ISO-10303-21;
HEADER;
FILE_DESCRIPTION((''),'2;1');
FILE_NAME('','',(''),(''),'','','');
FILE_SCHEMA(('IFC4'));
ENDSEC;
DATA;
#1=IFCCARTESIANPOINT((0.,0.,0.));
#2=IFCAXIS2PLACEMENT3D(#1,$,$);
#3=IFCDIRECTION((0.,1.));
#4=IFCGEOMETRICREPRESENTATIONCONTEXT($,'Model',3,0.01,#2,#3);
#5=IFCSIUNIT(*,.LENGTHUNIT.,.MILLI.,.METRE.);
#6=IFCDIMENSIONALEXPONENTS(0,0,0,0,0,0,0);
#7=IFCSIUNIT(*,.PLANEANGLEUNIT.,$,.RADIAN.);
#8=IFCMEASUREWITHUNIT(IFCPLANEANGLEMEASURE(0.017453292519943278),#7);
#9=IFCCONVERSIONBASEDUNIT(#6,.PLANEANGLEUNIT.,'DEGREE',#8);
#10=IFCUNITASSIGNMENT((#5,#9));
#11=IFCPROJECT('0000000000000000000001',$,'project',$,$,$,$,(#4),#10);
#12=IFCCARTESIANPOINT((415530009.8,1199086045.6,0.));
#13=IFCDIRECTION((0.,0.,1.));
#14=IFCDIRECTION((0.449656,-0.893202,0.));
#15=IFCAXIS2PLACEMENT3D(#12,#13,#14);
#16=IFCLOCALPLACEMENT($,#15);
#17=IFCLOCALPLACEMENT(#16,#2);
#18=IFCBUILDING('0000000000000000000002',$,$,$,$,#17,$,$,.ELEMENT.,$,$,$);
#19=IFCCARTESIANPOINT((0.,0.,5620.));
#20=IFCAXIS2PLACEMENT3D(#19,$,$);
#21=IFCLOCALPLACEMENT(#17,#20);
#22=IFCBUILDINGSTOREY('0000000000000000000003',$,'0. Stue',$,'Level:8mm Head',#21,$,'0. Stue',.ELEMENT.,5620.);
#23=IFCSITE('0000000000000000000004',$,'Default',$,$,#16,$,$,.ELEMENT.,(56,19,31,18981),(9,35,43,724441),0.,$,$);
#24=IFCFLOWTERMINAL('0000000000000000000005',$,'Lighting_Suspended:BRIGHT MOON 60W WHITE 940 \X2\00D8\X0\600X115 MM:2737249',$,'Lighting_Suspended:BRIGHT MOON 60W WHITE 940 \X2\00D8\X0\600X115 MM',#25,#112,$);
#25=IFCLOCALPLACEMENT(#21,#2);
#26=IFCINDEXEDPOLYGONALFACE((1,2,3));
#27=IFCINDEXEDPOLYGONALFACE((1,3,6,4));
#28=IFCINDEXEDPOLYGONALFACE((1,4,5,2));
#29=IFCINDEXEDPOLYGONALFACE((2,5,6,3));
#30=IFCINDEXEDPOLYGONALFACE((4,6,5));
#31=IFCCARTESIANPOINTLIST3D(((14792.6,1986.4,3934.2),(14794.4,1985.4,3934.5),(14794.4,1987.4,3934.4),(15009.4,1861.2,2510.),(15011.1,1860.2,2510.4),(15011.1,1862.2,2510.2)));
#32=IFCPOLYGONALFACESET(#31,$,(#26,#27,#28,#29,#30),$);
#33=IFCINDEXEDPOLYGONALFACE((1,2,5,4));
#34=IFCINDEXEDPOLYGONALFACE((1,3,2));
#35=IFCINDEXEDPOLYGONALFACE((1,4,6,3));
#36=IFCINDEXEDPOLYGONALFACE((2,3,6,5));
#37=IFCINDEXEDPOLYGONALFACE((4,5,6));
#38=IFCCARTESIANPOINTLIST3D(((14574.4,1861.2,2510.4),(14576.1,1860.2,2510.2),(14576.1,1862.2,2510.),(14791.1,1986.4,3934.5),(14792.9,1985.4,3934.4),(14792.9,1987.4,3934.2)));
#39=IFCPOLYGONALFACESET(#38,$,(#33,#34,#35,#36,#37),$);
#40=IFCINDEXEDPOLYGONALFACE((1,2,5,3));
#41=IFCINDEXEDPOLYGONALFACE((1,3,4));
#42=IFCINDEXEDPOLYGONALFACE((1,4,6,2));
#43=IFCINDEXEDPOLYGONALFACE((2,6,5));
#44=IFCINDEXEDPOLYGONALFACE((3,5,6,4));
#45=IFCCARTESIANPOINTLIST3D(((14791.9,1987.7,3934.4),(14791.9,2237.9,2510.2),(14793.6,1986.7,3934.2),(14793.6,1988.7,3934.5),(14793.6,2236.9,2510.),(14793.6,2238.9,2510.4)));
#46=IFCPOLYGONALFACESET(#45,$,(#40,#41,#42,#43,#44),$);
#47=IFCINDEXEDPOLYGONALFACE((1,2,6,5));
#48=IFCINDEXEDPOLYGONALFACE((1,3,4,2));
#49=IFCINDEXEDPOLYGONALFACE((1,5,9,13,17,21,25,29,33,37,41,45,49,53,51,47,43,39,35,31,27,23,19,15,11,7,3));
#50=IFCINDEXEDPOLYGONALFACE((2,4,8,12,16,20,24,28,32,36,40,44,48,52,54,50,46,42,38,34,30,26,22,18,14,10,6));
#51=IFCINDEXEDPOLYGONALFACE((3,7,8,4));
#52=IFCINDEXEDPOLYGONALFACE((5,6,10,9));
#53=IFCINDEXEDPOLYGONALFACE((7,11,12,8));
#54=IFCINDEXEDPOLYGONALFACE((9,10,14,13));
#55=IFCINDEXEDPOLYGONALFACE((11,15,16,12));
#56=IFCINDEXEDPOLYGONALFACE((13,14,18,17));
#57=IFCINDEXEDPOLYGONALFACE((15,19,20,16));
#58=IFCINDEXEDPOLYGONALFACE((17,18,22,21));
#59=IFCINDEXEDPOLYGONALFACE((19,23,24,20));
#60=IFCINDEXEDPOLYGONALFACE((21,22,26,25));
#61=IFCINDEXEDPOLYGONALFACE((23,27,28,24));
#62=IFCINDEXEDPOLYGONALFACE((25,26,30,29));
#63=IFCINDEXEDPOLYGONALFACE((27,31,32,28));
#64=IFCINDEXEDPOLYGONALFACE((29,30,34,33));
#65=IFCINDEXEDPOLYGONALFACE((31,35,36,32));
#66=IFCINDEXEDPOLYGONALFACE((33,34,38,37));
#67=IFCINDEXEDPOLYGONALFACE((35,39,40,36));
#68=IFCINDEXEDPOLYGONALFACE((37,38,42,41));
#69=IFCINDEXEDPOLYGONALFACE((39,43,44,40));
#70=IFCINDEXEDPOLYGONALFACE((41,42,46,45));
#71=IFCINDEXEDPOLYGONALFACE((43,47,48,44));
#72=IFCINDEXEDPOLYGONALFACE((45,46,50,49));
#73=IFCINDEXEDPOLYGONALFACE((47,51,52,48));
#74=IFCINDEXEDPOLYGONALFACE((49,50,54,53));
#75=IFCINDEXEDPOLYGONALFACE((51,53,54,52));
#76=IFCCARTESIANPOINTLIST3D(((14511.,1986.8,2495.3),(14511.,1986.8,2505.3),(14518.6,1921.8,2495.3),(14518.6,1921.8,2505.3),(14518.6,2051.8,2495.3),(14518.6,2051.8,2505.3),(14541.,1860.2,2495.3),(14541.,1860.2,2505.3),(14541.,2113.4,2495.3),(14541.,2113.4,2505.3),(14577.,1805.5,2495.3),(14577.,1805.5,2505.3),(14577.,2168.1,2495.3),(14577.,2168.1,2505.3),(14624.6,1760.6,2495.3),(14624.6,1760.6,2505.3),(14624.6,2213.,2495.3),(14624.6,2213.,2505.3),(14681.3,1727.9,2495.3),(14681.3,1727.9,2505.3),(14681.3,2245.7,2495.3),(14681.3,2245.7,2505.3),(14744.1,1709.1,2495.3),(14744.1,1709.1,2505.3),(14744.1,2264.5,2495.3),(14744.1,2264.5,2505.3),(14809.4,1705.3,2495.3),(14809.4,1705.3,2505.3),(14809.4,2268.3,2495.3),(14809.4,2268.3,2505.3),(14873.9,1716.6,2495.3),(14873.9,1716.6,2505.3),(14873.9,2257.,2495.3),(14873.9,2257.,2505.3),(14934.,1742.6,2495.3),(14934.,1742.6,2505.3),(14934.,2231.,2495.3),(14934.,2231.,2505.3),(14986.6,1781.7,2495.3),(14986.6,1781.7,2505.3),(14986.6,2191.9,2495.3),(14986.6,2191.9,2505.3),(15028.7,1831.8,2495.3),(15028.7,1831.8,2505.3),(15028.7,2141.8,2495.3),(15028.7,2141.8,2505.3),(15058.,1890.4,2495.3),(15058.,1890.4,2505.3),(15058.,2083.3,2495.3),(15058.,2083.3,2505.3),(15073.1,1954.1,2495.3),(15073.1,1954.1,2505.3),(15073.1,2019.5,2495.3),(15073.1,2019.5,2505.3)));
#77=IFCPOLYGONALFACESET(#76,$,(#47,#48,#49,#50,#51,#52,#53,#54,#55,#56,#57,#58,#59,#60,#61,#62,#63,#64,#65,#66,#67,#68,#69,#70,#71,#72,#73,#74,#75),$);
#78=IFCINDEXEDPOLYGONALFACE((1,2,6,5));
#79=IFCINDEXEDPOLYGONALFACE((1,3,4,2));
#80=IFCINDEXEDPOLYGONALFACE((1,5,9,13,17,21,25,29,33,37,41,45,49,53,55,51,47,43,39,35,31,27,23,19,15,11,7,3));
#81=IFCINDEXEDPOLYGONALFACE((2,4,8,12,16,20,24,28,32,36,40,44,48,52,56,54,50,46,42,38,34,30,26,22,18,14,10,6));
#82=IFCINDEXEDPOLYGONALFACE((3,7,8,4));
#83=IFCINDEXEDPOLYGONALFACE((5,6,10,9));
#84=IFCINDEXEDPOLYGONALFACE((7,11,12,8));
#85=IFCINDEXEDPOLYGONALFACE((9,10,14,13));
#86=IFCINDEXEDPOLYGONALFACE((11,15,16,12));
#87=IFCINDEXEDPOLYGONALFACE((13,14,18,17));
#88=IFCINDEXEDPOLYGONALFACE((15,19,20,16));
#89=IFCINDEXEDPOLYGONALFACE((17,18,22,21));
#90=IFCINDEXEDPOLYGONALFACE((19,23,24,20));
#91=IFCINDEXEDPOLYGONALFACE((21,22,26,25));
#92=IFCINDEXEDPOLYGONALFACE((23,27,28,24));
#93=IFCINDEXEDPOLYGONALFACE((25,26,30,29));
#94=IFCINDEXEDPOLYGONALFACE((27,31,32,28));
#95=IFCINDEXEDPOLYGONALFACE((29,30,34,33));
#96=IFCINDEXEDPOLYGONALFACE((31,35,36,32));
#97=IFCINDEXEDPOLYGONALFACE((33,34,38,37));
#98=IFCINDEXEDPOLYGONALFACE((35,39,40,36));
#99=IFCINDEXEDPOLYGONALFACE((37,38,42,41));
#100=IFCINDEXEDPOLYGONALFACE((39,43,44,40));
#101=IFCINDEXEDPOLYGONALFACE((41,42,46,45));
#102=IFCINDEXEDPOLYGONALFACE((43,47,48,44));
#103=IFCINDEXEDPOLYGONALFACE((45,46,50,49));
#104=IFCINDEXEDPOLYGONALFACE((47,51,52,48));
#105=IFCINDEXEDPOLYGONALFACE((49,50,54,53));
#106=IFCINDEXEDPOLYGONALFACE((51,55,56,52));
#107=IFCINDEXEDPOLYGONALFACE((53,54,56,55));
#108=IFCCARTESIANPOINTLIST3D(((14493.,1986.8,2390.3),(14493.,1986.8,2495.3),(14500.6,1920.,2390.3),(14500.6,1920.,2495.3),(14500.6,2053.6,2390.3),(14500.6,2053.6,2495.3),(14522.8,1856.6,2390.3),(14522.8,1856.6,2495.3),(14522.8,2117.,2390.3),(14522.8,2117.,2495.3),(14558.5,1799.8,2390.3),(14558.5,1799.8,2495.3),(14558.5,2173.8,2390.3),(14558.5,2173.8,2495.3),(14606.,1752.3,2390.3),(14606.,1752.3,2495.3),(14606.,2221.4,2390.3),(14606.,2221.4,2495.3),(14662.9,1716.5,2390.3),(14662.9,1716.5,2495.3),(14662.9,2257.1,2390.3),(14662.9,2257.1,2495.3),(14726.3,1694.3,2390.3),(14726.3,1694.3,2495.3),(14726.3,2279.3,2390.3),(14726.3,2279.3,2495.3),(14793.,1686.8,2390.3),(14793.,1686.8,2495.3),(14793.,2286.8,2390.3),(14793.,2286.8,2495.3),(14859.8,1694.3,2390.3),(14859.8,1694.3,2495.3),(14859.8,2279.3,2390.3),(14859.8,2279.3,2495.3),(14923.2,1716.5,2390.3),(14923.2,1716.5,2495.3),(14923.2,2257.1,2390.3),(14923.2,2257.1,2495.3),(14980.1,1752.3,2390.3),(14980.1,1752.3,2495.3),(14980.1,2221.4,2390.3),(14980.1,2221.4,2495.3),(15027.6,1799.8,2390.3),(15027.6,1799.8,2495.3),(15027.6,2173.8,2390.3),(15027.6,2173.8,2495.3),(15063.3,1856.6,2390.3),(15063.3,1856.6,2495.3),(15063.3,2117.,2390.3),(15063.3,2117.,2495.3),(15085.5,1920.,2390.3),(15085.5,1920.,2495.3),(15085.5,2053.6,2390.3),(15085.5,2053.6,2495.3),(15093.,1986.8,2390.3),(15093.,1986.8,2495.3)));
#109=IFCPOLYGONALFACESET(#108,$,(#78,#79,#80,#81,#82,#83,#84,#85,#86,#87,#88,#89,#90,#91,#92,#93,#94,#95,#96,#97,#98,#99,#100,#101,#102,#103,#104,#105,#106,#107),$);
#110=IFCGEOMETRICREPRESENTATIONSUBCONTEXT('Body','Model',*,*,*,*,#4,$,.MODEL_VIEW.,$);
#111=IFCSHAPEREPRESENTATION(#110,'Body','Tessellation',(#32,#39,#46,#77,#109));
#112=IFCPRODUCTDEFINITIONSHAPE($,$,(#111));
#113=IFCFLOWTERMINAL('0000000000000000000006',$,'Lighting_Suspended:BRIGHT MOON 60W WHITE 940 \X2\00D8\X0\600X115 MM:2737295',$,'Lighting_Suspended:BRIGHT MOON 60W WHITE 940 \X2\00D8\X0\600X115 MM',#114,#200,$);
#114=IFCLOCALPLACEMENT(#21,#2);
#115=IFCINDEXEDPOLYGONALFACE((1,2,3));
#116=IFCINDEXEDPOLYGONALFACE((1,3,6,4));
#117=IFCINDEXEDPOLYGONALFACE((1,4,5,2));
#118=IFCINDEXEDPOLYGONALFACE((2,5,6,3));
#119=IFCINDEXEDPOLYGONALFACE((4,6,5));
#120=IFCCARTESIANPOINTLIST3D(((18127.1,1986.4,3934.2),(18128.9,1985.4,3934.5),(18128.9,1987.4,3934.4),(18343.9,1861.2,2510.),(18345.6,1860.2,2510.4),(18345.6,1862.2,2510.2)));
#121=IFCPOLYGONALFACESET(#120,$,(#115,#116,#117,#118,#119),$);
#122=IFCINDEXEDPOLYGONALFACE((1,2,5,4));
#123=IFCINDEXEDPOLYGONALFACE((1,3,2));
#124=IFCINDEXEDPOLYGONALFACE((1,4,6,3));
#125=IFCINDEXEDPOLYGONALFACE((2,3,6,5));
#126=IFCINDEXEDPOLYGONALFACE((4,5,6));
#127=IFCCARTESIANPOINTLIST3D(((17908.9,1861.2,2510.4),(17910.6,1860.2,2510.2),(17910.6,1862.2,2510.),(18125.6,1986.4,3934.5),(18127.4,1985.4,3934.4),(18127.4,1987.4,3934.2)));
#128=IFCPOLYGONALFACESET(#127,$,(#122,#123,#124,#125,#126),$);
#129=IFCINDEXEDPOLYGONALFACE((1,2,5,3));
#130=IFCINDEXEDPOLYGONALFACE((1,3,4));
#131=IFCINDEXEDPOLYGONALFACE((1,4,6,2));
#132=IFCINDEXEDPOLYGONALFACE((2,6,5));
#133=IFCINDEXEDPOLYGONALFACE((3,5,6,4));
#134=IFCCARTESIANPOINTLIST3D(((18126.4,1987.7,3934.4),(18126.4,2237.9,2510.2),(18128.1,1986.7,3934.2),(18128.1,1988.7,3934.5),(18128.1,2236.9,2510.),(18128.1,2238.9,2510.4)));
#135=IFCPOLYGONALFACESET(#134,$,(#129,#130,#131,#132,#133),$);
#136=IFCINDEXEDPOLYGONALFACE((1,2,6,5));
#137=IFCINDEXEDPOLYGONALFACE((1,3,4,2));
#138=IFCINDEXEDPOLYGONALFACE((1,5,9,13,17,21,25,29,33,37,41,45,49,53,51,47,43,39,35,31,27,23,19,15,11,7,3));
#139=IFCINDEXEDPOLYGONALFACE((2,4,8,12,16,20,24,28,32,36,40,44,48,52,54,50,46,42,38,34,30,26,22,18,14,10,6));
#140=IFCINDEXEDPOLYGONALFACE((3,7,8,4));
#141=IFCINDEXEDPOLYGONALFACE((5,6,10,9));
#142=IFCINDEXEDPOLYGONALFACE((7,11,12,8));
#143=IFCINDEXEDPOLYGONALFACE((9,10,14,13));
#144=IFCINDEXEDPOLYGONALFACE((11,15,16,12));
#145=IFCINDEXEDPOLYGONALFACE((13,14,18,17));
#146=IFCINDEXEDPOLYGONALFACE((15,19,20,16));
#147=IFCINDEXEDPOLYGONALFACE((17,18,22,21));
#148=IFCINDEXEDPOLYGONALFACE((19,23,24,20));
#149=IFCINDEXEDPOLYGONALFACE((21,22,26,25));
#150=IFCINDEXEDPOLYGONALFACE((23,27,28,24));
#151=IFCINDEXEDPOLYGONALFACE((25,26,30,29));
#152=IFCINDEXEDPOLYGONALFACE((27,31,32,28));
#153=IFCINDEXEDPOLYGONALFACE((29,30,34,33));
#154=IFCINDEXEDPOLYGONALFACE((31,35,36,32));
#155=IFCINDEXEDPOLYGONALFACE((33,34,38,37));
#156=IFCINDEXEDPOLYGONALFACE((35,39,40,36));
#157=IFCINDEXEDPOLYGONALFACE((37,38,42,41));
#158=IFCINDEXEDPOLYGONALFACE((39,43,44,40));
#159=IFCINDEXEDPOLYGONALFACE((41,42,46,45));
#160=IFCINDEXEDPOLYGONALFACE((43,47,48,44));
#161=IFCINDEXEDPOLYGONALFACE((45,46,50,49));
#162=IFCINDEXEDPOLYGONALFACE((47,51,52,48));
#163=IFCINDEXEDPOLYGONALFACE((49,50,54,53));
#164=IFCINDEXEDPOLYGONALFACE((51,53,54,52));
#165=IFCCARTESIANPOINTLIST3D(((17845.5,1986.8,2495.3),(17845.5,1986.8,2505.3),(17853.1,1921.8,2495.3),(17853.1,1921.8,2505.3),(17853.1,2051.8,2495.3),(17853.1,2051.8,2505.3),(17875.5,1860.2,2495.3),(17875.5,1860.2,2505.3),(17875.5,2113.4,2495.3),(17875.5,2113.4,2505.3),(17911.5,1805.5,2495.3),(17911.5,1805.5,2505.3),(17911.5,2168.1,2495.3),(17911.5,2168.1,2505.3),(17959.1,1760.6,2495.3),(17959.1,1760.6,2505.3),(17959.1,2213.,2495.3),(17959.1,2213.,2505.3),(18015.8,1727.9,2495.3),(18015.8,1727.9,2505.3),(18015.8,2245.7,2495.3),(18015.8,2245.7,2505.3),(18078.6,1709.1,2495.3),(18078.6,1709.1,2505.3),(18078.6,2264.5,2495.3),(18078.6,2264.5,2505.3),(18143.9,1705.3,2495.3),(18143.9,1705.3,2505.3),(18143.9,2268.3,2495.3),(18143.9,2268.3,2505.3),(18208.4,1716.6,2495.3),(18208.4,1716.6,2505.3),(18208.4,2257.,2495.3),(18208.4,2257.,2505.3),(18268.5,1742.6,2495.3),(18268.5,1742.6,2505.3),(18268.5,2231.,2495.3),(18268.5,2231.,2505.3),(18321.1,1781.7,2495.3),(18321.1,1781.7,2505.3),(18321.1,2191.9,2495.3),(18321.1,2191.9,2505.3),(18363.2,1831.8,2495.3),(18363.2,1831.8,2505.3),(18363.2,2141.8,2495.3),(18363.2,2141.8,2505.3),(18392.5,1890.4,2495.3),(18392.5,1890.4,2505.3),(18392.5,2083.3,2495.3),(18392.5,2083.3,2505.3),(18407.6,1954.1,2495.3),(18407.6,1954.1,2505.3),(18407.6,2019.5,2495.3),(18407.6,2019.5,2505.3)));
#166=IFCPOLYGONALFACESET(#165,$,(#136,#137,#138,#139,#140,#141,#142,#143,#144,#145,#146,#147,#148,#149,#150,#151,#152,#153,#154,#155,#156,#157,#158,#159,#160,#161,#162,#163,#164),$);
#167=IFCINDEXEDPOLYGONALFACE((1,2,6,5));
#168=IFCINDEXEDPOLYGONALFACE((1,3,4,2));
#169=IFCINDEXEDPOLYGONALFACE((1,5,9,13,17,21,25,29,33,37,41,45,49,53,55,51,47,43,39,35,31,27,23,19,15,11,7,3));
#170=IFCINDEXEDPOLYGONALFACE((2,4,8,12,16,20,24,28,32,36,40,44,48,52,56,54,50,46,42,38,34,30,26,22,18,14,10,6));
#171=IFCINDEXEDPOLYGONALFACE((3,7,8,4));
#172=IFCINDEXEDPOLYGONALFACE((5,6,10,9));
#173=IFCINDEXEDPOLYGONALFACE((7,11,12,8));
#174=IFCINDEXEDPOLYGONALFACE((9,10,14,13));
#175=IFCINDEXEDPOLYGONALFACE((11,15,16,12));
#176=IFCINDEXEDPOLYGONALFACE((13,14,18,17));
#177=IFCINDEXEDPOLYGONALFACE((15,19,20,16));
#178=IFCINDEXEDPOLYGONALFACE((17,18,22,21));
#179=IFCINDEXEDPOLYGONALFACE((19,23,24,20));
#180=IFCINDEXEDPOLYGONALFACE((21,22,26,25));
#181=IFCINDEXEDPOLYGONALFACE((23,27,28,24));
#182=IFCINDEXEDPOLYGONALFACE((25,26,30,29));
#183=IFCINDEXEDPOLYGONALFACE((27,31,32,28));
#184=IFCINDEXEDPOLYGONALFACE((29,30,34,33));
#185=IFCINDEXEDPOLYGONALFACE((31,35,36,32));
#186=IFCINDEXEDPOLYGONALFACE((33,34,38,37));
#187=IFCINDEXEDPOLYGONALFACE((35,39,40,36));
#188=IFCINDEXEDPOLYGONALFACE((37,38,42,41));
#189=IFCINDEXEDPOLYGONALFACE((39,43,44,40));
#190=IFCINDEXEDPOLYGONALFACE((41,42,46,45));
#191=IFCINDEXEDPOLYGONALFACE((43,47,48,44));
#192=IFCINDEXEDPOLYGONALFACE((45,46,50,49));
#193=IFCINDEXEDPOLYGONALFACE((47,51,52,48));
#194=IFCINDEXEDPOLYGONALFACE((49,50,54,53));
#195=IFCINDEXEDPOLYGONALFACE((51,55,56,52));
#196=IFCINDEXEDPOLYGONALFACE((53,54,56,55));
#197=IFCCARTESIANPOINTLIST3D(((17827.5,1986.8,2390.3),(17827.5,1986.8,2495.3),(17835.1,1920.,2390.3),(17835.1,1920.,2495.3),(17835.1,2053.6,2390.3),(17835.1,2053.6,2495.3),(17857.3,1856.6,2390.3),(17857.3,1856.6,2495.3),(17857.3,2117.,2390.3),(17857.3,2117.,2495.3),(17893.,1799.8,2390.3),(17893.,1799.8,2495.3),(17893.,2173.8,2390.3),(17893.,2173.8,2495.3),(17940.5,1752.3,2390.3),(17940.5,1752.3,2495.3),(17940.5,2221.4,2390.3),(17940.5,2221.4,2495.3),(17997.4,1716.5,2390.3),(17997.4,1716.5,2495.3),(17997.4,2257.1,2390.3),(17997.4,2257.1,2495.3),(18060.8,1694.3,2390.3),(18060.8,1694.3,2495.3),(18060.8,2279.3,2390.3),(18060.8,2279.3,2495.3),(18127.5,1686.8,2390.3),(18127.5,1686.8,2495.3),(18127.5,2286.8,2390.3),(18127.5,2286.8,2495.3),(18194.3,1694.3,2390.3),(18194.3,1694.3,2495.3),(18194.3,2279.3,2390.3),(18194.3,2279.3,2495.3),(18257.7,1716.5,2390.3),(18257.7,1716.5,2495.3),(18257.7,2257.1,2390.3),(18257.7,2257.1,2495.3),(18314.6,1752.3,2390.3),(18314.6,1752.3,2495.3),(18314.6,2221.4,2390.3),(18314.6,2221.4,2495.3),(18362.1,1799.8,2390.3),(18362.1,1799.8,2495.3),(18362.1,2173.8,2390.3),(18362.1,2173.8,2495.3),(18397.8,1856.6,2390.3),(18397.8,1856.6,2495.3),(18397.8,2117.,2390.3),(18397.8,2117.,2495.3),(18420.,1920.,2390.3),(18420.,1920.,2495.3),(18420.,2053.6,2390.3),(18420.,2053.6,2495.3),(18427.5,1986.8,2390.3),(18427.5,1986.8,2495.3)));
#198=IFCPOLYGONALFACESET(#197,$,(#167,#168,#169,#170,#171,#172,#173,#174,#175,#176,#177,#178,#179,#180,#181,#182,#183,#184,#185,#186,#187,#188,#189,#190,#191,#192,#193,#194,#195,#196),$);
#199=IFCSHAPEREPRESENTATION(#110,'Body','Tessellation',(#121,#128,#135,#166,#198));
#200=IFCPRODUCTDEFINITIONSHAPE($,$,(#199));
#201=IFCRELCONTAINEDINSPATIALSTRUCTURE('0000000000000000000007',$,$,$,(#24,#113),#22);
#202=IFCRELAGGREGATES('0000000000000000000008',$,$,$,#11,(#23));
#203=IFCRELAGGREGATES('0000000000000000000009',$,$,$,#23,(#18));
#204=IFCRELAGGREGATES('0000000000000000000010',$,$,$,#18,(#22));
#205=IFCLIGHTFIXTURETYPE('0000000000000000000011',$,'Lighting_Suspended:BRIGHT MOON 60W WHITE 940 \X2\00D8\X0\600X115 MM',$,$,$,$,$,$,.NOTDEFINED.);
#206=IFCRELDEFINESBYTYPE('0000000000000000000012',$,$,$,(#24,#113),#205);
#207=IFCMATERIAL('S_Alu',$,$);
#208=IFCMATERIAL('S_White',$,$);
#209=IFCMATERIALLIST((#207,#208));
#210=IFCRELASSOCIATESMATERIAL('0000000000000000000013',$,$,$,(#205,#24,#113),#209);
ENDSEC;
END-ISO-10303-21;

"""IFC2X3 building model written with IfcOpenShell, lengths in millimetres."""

from ifc_helpers import new_model, entity, si_unit, converted_unit, direction, frame, frame_2d, origin, place, context, subcontext, project, spatial, polyline, circle, outline, extrude, source, transform, mapped, material, material_list, type_object, type_shapes, element, save


model = new_model("IFC2X3")

# Units and contexts
model_context = context("Model", 3, precision=0.01, world=origin(), true_north=direction((0.0, 1.0)))
body_context = subcontext(model_context, "Body", "Model", "MODEL_VIEW")
ifc_project = project(units=[si_unit("LENGTHUNIT", "METRE", prefix="MILLI"), converted_unit("PLANEANGLEUNIT", "DEGREE", entity("IfcPlaneAngleMeasure", 0.017453292519943278), si_unit("PLANEANGLEUNIT", "RADIAN"), dimensions=[0, 0, 0, 0, 0, 0, 0])], contexts=[model_context])

# Site, building, storey
site_placement = place(None, frame((415530009.8, 1199086045.6, 0.0), z_axis=(0.0, 0.0, 1.0), x_axis=(0.449656, -0.893202, 0.0)))
site = spatial("IfcSite", under=ifc_project, at=site_placement, Name="Default", CompositionType="ELEMENT", RefLatitude=(56, 19, 31, 18981), RefLongitude=(9, 35, 43, 724441), RefElevation=0.0)
building_placement = place(site_placement, origin())
building = spatial("IfcBuilding", under=site, at=building_placement, CompositionType="ELEMENT")
storey_placement = place(building_placement, frame((0.0, 0.0, 5620.0)))
storey = spatial("IfcBuildingStorey", under=building, at=storey_placement, Name="0. Stue", ObjectType="Level:8mm Head", LongName="0. Stue", CompositionType="ELEMENT", Elevation=5620.0)

# Flow terminals
ifc_material_1 = material(Name="S_White")
ifc_material_2 = material(Name="S_Alu")
ifc_material_list = material_list([ifc_material_2, ifc_material_1])
light_fixture_type_1 = type_object("IfcLightFixtureType", Name="Lighting_Suspended:BRIGHT MOON 60W WHITE 940 Ø600X115 MM", PredefinedType="NOTDEFINED", material=ifc_material_list)
shared_shape_1 = source(origin(), body_context, "Body", "SweptSolid", [
    extrude(outline(polyline([(-1.0, -0.6), (1.0, -0.6), (0.0, 1.2), (-1.0, -0.6)])), frame((-217.5, 125.6, -1429.1), z_axis=(0.149892, -0.08654, 0.984908), x_axis=(-0.852955, 0.492454, 0.17308)), (0.0, 0.0, 1.0), 1446.0),
    extrude(outline(polyline([(-1.0, -0.6), (1.0, -0.6), (0.0, 1.2), (-1.0, -0.6)])), frame((217.5, 125.6, -1429.1), z_axis=(-0.149892, -0.08654, 0.984908), x_axis=(0.852955, 0.492454, 0.17308)), (0.0, 0.0, 1.0), 1446.0),
    extrude(outline(polyline([(-1.0, -0.6), (1.0, -0.6), (0.0, 1.2), (-1.0, -0.6)])), frame((0.0, -251.1, -1429.1), z_axis=(0.0, 0.17308, 0.984908), x_axis=(0.0, -0.984908, 0.17308)), (0.0, 0.0, 1.0), 1446.0),
    extrude(circle(Radius=282.0, at=frame_2d((0.0, 0.0), x_axis=(1.0, 0.0))), frame((0.0, 0.0, -1444.0)), (0.0, 0.0, 1.0), 10.0),
    extrude(circle(Radius=300.0, at=frame_2d((0.0, 0.0), x_axis=(1.0, 0.0))), frame((0.0, 0.0, -1549.0)), (0.0, 0.0, 1.0), 105.0),
])
type_shapes(light_fixture_type_1, [shared_shape_1])
for number, where, z_axis, x_axis, name in (
    (1, (14793.0, 1986.8, 3939.3), (0.0, 0.0, 1.0), (-1.0, 0.0, 0.0), "Lighting_Suspended:BRIGHT MOON 60W WHITE 940 Ø600X115 MM:2737249"),
    (2, (18127.5, 1986.8, 3939.3), (0.0, 0.0, 1.0), (-1.0, 0.0, 0.0), "Lighting_Suspended:BRIGHT MOON 60W WHITE 940 Ø600X115 MM:2737295"),
):
    element("IfcFlowTerminal", number, at=place(storey_placement, frame(where, z_axis=z_axis, x_axis=x_axis)), inside=storey, type_object=light_fixture_type_1, material=ifc_material_list, Name=name, ObjectType="Lighting_Suspended:BRIGHT MOON 60W WHITE 940 Ø600X115 MM", context=body_context, shape_type="MappedRepresentation", body=[
        mapped(shared_shape_1, transform((0.0, 0.0, 0.0), scale=1.0)),
    ])

save(model, "model.ifc")
